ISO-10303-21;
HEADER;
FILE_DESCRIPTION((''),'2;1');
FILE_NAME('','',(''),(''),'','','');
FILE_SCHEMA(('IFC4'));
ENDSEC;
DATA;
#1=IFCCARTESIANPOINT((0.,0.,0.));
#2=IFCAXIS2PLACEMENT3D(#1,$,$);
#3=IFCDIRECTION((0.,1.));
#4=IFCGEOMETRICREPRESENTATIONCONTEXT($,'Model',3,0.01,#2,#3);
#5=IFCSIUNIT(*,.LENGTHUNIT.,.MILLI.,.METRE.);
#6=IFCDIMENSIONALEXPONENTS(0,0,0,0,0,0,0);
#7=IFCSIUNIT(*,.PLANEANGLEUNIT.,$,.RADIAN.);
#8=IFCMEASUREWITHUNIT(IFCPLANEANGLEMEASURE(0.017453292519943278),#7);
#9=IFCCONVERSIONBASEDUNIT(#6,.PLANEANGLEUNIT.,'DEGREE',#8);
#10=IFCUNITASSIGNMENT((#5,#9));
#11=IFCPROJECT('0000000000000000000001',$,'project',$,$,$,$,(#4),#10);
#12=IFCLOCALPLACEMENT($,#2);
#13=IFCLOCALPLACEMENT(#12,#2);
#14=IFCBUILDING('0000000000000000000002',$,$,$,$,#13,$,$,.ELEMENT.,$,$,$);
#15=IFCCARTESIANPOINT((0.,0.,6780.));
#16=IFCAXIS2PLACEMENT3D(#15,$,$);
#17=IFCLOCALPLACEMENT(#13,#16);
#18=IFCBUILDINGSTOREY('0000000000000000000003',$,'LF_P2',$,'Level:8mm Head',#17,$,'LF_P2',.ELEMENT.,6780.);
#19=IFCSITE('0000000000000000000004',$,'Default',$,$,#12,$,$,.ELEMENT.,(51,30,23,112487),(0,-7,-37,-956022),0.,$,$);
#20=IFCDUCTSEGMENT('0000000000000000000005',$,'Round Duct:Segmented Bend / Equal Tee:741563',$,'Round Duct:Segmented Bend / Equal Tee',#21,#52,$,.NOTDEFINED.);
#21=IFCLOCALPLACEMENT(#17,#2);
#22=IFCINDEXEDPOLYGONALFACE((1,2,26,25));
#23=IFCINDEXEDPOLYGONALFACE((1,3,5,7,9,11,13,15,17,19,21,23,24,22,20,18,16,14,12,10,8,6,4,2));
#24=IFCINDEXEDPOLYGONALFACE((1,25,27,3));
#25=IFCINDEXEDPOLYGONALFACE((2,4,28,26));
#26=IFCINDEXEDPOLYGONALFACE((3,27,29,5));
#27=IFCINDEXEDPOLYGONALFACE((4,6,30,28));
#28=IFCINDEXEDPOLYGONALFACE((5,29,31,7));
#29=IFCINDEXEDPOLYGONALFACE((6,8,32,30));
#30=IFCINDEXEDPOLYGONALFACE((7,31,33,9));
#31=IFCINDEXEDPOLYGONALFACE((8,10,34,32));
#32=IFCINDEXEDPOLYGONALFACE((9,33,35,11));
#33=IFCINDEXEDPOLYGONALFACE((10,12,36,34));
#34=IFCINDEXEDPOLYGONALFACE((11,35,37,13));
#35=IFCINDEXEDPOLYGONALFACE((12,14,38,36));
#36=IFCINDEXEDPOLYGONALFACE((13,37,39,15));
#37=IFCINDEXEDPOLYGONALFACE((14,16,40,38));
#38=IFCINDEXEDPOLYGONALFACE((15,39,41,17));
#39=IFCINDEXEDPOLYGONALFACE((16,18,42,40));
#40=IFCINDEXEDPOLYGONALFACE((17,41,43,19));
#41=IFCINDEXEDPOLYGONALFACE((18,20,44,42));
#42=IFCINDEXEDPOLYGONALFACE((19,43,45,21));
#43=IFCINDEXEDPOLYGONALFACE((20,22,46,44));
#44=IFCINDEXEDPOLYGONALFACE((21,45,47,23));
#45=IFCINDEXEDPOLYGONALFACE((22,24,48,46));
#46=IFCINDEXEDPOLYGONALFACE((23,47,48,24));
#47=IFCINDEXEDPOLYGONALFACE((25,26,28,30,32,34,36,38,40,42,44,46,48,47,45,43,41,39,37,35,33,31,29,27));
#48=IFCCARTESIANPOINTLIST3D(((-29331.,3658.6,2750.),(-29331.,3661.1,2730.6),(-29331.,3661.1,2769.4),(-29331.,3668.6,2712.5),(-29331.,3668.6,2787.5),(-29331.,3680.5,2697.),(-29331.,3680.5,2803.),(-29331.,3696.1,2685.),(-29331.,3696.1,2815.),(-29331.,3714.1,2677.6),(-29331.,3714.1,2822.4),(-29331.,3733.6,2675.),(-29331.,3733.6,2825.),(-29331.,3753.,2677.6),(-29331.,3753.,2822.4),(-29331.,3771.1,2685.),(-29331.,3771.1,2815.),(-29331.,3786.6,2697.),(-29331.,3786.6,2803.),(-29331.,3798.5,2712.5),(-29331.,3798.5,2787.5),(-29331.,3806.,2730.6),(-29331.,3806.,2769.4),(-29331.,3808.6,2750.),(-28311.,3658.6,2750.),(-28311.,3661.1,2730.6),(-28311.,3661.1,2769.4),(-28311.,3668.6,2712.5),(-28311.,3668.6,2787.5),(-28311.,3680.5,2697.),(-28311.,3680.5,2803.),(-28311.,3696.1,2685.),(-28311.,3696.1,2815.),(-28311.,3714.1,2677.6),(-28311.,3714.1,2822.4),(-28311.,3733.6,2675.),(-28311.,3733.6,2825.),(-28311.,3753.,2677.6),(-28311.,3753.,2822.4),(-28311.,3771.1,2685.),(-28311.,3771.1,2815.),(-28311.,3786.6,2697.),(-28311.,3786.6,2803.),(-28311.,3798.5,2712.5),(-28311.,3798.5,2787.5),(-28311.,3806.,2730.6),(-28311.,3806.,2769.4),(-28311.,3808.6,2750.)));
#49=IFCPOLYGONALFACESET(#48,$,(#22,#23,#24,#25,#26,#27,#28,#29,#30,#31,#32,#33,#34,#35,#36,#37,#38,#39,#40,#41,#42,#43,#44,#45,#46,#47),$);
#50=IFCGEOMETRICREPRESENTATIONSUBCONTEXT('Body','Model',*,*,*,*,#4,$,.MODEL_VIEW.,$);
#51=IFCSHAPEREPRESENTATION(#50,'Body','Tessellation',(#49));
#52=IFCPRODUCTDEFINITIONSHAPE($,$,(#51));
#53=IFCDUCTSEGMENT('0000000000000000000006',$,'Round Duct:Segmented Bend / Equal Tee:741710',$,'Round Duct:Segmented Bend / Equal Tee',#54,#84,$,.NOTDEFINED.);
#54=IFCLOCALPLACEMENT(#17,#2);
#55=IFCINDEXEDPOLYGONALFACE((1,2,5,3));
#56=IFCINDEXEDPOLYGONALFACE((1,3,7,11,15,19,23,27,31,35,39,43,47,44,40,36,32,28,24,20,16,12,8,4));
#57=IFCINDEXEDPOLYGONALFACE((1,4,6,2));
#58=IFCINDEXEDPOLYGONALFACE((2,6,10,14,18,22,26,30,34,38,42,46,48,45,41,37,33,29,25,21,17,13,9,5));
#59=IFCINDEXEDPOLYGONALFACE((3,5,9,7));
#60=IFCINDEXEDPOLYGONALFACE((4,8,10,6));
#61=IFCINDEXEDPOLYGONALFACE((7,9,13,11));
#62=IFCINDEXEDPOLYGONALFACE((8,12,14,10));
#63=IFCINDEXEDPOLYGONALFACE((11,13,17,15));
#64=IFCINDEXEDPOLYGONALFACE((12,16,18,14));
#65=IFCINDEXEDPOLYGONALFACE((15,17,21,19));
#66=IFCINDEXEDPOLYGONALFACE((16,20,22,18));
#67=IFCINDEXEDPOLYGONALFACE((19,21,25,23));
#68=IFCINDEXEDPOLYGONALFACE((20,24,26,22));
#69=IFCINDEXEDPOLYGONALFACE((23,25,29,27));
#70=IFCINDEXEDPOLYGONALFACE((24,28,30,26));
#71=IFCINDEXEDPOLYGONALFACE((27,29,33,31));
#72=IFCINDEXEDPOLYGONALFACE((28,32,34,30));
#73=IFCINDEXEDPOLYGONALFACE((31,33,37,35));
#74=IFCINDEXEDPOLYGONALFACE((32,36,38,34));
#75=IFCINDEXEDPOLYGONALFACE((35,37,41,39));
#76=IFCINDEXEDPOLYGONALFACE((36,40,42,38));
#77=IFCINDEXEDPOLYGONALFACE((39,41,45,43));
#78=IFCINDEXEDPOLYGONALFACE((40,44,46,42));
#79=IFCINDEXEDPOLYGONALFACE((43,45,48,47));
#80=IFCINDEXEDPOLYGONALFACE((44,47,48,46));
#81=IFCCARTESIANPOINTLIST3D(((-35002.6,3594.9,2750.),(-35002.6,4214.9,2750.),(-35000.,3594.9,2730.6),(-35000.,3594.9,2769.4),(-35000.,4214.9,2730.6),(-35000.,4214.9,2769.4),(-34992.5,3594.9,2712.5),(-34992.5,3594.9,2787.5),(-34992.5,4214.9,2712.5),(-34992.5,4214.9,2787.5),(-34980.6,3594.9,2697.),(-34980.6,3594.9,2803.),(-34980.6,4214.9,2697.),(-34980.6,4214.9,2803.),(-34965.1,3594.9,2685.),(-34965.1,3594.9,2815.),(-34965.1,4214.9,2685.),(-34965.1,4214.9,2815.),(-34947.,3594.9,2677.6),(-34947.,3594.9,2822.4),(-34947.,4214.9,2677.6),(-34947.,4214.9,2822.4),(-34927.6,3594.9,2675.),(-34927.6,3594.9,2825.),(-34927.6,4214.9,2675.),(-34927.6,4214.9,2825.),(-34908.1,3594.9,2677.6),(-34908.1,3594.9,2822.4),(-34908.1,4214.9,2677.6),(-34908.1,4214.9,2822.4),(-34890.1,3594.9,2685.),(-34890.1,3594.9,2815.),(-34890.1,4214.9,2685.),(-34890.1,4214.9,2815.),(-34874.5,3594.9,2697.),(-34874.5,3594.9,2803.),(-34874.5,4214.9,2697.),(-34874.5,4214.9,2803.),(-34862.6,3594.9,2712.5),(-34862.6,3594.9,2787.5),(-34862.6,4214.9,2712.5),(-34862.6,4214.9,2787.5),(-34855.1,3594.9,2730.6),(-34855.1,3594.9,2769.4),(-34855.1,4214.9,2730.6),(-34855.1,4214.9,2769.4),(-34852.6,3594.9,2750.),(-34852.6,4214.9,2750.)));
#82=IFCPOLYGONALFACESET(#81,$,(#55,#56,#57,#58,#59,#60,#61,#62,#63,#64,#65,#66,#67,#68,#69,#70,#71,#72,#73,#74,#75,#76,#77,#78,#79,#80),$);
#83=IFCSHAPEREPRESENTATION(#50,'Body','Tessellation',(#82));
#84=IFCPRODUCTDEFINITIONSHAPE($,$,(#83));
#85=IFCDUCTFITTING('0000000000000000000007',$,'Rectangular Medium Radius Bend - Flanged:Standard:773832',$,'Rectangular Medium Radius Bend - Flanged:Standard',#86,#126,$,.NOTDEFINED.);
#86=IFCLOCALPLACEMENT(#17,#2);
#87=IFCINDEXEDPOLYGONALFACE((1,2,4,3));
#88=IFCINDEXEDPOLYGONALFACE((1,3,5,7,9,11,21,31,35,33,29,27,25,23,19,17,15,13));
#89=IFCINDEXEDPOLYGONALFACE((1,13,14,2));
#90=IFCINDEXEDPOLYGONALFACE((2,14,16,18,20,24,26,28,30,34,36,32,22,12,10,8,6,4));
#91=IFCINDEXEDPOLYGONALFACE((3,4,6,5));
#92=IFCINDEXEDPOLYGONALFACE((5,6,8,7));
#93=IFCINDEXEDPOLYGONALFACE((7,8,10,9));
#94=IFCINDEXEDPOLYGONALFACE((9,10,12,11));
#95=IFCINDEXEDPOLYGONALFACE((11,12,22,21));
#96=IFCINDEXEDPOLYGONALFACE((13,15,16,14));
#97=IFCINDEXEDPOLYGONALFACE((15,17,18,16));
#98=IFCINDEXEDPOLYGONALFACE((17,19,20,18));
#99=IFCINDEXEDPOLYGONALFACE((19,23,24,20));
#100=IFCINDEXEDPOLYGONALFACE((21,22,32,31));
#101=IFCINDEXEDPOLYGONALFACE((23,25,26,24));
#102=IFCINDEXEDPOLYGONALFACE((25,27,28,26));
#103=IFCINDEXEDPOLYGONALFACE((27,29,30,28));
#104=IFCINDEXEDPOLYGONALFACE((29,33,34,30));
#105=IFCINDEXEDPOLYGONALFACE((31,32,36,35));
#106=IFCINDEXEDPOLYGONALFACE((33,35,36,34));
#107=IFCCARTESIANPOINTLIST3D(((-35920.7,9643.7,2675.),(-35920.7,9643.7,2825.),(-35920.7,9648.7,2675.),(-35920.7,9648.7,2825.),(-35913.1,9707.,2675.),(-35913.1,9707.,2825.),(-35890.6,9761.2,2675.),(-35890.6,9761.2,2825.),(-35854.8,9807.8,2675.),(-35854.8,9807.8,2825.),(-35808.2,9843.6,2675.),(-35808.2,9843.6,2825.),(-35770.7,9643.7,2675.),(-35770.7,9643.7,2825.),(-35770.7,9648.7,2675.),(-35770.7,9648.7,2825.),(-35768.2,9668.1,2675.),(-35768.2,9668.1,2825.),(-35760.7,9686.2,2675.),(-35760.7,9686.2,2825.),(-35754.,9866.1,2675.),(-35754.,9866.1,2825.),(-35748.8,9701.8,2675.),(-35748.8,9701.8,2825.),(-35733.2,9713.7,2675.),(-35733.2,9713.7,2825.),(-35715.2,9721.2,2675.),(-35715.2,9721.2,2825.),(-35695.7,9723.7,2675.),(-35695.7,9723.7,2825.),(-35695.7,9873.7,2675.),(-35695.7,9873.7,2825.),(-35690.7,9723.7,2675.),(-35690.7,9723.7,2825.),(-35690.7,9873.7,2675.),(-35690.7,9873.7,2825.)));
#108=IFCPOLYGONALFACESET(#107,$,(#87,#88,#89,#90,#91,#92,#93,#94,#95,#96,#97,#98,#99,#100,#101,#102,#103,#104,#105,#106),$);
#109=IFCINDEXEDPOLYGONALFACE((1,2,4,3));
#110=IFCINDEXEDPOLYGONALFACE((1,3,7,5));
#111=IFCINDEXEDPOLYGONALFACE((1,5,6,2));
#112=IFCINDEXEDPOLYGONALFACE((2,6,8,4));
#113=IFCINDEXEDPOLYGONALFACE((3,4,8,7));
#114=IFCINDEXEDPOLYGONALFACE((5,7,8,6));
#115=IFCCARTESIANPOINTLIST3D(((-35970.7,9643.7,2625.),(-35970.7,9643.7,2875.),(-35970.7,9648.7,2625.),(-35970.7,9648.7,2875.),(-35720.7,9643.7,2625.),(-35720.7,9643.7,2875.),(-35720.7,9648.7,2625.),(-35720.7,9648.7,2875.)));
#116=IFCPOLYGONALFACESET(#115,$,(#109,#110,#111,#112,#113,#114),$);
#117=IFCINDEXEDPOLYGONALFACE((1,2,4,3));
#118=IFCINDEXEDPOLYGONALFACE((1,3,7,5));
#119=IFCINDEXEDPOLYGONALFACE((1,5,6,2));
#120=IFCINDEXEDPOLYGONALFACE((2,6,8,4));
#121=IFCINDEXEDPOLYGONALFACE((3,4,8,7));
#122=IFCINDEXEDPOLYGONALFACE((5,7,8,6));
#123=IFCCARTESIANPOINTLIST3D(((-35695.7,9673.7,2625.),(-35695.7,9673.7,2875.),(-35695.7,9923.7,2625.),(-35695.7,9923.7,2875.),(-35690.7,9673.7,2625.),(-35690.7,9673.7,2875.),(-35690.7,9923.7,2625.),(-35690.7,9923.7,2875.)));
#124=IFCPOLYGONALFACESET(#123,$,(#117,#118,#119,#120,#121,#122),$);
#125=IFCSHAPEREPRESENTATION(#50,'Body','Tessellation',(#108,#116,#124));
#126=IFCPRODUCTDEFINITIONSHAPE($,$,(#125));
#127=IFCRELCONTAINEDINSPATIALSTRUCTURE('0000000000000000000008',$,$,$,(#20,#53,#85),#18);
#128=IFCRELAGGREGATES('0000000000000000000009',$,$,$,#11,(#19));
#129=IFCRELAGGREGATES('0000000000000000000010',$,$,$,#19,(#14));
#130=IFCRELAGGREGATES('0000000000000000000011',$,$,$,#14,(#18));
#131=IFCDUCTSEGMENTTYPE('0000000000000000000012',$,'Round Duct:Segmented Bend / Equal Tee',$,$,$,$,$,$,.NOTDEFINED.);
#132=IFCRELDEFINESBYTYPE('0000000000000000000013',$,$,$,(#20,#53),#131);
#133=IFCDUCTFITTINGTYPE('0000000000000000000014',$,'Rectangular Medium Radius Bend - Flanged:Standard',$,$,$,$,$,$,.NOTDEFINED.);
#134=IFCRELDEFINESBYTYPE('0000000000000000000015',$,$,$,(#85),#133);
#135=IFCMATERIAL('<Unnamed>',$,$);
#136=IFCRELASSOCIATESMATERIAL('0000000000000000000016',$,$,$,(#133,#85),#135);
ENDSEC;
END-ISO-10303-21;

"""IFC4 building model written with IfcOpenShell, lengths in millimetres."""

from ifc_helpers import new_model, entity, si_unit, converted_unit, direction, frame, origin, place, context, subcontext, project, spatial, line, arc, indexed_curve, outline, extrude, source, transform, mapped, material, type_object, type_shapes, element, save


model = new_model("IFC4")

# Units and contexts
model_context = context("Model", 3, precision=0.01, world=origin(), true_north=direction((0.0, 1.0)))
body_context = subcontext(model_context, "Body", "Model", "MODEL_VIEW")
ifc_project = project(units=[si_unit("LENGTHUNIT", "METRE", prefix="MILLI"), converted_unit("PLANEANGLEUNIT", "DEGREE", entity("IfcPlaneAngleMeasure", 0.017453292519943278), si_unit("PLANEANGLEUNIT", "RADIAN"), dimensions=[0, 0, 0, 0, 0, 0, 0])], contexts=[model_context])

# Site, building, storey
site_placement = place(None, origin())
site = spatial("IfcSite", under=ifc_project, at=site_placement, Name="Default", CompositionType="ELEMENT", RefLatitude=(51, 30, 23, 112487), RefLongitude=(0, -7, -37, -956022), RefElevation=0.0)
building_placement = place(site_placement, origin())
building = spatial("IfcBuilding", under=site, at=building_placement, CompositionType="ELEMENT")
storey_placement = place(building_placement, frame((0.0, 0.0, 6780.0)))
storey = spatial("IfcBuildingStorey", under=building, at=storey_placement, Name="LF_P2", ObjectType="Level:8mm Head", LongName="LF_P2", CompositionType="ELEMENT", Elevation=6780.0)

# Duct segments
duct_segment_type_1 = type_object("IfcDuctSegmentType", Name="Round Duct:Segmented Bend / Equal Tee", PredefinedType="NOTDEFINED")
duct_segment_1_placement = place(storey_placement, origin())
element("IfcDuctSegment", 1, at=duct_segment_1_placement, inside=storey, type_object=duct_segment_type_1, Name="Round Duct:Segmented Bend / Equal Tee:741563", ObjectType="Round Duct:Segmented Bend / Equal Tee", PredefinedType="NOTDEFINED", context=body_context, shape_type="SweptSolid", body=[
    extrude(outline(indexed_curve([(75.0, 0.0), (53.0, 53.0), (0.0, 75.0), (-53.0, 53.0), (-75.0, 0.0), (-53.0, -53.0), (0.0, -75.0), (53.0, -53.0)], segments=[arc(1, 2, 3), arc(3, 4, 5), arc(5, 6, 7), arc(7, 8, 1)], self_intersect=False)), frame((-29331.0, 3733.6, 2750.0), z_axis=(1.0, 0.0, 0.0), x_axis=(0.0, 1.0, 0.0)), (0.0, 0.0, 1.0), 1020.0),
])
duct_segment_2_placement = place(storey_placement, origin())
element("IfcDuctSegment", 2, at=duct_segment_2_placement, inside=storey, type_object=duct_segment_type_1, Name="Round Duct:Segmented Bend / Equal Tee:741710", ObjectType="Round Duct:Segmented Bend / Equal Tee", PredefinedType="NOTDEFINED", context=body_context, shape_type="SweptSolid", body=[
    extrude(outline(indexed_curve([(75.0, 0.0), (53.0, 53.0), (0.0, 75.0), (-53.0, 53.0), (-75.0, 0.0), (-53.0, -53.0), (0.0, -75.0), (53.0, -53.0)], segments=[arc(1, 2, 3), arc(3, 4, 5), arc(5, 6, 7), arc(7, 8, 1)], self_intersect=False)), frame((-34927.6, 3594.9, 2750.0), z_axis=(0.0, 1.0, 0.0), x_axis=(1.0, 0.0, 0.0)), (0.0, 0.0, 1.0), 620.0),
])

# Duct fitting
ifc_material = material(Name="<Unnamed>")
duct_fitting_type = type_object("IfcDuctFittingType", Name="Rectangular Medium Radius Bend - Flanged:Standard", PredefinedType="NOTDEFINED", material=ifc_material)
shared_shape_1 = source(origin(), body_context, "Body", "SweptSolid", [
    extrude(outline(indexed_curve([(-78.8, -151.2), (-73.7, -151.2), (85.3, -85.3), (151.3, 73.7), (151.3, 78.7), (1.3, 78.7), (1.3, 73.8), (-20.7, 20.7), (-73.7, -1.2), (-78.8, -1.2)], segments=[line(1, 2), arc(2, 3, 4), line(4, 5, 6, 7), arc(7, 8, 9), line(9, 10, 1)], self_intersect=False)), frame((-76.2, 76.2, -75.0)), (0.0, 0.0, 1.0), 150.0),
    extrude(outline(indexed_curve([(-2.5, -125.0), (2.5, -125.0), (2.5, 125.0), (-2.5, 125.0), (-2.5, -125.0)], self_intersect=False)), frame((0.0, 152.5, -125.0), z_axis=(0.0, 0.0, 1.0), x_axis=(0.0, 1.0, 0.0)), (0.0, 0.0, 1.0), 250.0),
    extrude(outline(indexed_curve([(-2.5, -125.0), (2.5, -125.0), (2.5, 125.0), (-2.5, 125.0), (-2.5, -125.0)], self_intersect=False)), frame((-152.5, 0.0, -125.0)), (0.0, 0.0, 1.0), 250.0),
])
type_shapes(duct_fitting_type, [shared_shape_1])
duct_fitting_placement = place(storey_placement, frame((-35845.7, 9798.7, 2750.0), z_axis=(0.0, 0.0, 1.0), x_axis=(-1.0, 0.0, 0.0)))
element("IfcDuctFitting", 3, at=duct_fitting_placement, inside=storey, type_object=duct_fitting_type, material=ifc_material, Name="Rectangular Medium Radius Bend - Flanged:Standard:773832", ObjectType="Rectangular Medium Radius Bend - Flanged:Standard", PredefinedType="NOTDEFINED", context=body_context, shape_type="MappedRepresentation", body=[
    mapped(shared_shape_1, transform((0.0, 0.0, 0.0), scale=1.0)),
])

save(model, "model.ifc")
